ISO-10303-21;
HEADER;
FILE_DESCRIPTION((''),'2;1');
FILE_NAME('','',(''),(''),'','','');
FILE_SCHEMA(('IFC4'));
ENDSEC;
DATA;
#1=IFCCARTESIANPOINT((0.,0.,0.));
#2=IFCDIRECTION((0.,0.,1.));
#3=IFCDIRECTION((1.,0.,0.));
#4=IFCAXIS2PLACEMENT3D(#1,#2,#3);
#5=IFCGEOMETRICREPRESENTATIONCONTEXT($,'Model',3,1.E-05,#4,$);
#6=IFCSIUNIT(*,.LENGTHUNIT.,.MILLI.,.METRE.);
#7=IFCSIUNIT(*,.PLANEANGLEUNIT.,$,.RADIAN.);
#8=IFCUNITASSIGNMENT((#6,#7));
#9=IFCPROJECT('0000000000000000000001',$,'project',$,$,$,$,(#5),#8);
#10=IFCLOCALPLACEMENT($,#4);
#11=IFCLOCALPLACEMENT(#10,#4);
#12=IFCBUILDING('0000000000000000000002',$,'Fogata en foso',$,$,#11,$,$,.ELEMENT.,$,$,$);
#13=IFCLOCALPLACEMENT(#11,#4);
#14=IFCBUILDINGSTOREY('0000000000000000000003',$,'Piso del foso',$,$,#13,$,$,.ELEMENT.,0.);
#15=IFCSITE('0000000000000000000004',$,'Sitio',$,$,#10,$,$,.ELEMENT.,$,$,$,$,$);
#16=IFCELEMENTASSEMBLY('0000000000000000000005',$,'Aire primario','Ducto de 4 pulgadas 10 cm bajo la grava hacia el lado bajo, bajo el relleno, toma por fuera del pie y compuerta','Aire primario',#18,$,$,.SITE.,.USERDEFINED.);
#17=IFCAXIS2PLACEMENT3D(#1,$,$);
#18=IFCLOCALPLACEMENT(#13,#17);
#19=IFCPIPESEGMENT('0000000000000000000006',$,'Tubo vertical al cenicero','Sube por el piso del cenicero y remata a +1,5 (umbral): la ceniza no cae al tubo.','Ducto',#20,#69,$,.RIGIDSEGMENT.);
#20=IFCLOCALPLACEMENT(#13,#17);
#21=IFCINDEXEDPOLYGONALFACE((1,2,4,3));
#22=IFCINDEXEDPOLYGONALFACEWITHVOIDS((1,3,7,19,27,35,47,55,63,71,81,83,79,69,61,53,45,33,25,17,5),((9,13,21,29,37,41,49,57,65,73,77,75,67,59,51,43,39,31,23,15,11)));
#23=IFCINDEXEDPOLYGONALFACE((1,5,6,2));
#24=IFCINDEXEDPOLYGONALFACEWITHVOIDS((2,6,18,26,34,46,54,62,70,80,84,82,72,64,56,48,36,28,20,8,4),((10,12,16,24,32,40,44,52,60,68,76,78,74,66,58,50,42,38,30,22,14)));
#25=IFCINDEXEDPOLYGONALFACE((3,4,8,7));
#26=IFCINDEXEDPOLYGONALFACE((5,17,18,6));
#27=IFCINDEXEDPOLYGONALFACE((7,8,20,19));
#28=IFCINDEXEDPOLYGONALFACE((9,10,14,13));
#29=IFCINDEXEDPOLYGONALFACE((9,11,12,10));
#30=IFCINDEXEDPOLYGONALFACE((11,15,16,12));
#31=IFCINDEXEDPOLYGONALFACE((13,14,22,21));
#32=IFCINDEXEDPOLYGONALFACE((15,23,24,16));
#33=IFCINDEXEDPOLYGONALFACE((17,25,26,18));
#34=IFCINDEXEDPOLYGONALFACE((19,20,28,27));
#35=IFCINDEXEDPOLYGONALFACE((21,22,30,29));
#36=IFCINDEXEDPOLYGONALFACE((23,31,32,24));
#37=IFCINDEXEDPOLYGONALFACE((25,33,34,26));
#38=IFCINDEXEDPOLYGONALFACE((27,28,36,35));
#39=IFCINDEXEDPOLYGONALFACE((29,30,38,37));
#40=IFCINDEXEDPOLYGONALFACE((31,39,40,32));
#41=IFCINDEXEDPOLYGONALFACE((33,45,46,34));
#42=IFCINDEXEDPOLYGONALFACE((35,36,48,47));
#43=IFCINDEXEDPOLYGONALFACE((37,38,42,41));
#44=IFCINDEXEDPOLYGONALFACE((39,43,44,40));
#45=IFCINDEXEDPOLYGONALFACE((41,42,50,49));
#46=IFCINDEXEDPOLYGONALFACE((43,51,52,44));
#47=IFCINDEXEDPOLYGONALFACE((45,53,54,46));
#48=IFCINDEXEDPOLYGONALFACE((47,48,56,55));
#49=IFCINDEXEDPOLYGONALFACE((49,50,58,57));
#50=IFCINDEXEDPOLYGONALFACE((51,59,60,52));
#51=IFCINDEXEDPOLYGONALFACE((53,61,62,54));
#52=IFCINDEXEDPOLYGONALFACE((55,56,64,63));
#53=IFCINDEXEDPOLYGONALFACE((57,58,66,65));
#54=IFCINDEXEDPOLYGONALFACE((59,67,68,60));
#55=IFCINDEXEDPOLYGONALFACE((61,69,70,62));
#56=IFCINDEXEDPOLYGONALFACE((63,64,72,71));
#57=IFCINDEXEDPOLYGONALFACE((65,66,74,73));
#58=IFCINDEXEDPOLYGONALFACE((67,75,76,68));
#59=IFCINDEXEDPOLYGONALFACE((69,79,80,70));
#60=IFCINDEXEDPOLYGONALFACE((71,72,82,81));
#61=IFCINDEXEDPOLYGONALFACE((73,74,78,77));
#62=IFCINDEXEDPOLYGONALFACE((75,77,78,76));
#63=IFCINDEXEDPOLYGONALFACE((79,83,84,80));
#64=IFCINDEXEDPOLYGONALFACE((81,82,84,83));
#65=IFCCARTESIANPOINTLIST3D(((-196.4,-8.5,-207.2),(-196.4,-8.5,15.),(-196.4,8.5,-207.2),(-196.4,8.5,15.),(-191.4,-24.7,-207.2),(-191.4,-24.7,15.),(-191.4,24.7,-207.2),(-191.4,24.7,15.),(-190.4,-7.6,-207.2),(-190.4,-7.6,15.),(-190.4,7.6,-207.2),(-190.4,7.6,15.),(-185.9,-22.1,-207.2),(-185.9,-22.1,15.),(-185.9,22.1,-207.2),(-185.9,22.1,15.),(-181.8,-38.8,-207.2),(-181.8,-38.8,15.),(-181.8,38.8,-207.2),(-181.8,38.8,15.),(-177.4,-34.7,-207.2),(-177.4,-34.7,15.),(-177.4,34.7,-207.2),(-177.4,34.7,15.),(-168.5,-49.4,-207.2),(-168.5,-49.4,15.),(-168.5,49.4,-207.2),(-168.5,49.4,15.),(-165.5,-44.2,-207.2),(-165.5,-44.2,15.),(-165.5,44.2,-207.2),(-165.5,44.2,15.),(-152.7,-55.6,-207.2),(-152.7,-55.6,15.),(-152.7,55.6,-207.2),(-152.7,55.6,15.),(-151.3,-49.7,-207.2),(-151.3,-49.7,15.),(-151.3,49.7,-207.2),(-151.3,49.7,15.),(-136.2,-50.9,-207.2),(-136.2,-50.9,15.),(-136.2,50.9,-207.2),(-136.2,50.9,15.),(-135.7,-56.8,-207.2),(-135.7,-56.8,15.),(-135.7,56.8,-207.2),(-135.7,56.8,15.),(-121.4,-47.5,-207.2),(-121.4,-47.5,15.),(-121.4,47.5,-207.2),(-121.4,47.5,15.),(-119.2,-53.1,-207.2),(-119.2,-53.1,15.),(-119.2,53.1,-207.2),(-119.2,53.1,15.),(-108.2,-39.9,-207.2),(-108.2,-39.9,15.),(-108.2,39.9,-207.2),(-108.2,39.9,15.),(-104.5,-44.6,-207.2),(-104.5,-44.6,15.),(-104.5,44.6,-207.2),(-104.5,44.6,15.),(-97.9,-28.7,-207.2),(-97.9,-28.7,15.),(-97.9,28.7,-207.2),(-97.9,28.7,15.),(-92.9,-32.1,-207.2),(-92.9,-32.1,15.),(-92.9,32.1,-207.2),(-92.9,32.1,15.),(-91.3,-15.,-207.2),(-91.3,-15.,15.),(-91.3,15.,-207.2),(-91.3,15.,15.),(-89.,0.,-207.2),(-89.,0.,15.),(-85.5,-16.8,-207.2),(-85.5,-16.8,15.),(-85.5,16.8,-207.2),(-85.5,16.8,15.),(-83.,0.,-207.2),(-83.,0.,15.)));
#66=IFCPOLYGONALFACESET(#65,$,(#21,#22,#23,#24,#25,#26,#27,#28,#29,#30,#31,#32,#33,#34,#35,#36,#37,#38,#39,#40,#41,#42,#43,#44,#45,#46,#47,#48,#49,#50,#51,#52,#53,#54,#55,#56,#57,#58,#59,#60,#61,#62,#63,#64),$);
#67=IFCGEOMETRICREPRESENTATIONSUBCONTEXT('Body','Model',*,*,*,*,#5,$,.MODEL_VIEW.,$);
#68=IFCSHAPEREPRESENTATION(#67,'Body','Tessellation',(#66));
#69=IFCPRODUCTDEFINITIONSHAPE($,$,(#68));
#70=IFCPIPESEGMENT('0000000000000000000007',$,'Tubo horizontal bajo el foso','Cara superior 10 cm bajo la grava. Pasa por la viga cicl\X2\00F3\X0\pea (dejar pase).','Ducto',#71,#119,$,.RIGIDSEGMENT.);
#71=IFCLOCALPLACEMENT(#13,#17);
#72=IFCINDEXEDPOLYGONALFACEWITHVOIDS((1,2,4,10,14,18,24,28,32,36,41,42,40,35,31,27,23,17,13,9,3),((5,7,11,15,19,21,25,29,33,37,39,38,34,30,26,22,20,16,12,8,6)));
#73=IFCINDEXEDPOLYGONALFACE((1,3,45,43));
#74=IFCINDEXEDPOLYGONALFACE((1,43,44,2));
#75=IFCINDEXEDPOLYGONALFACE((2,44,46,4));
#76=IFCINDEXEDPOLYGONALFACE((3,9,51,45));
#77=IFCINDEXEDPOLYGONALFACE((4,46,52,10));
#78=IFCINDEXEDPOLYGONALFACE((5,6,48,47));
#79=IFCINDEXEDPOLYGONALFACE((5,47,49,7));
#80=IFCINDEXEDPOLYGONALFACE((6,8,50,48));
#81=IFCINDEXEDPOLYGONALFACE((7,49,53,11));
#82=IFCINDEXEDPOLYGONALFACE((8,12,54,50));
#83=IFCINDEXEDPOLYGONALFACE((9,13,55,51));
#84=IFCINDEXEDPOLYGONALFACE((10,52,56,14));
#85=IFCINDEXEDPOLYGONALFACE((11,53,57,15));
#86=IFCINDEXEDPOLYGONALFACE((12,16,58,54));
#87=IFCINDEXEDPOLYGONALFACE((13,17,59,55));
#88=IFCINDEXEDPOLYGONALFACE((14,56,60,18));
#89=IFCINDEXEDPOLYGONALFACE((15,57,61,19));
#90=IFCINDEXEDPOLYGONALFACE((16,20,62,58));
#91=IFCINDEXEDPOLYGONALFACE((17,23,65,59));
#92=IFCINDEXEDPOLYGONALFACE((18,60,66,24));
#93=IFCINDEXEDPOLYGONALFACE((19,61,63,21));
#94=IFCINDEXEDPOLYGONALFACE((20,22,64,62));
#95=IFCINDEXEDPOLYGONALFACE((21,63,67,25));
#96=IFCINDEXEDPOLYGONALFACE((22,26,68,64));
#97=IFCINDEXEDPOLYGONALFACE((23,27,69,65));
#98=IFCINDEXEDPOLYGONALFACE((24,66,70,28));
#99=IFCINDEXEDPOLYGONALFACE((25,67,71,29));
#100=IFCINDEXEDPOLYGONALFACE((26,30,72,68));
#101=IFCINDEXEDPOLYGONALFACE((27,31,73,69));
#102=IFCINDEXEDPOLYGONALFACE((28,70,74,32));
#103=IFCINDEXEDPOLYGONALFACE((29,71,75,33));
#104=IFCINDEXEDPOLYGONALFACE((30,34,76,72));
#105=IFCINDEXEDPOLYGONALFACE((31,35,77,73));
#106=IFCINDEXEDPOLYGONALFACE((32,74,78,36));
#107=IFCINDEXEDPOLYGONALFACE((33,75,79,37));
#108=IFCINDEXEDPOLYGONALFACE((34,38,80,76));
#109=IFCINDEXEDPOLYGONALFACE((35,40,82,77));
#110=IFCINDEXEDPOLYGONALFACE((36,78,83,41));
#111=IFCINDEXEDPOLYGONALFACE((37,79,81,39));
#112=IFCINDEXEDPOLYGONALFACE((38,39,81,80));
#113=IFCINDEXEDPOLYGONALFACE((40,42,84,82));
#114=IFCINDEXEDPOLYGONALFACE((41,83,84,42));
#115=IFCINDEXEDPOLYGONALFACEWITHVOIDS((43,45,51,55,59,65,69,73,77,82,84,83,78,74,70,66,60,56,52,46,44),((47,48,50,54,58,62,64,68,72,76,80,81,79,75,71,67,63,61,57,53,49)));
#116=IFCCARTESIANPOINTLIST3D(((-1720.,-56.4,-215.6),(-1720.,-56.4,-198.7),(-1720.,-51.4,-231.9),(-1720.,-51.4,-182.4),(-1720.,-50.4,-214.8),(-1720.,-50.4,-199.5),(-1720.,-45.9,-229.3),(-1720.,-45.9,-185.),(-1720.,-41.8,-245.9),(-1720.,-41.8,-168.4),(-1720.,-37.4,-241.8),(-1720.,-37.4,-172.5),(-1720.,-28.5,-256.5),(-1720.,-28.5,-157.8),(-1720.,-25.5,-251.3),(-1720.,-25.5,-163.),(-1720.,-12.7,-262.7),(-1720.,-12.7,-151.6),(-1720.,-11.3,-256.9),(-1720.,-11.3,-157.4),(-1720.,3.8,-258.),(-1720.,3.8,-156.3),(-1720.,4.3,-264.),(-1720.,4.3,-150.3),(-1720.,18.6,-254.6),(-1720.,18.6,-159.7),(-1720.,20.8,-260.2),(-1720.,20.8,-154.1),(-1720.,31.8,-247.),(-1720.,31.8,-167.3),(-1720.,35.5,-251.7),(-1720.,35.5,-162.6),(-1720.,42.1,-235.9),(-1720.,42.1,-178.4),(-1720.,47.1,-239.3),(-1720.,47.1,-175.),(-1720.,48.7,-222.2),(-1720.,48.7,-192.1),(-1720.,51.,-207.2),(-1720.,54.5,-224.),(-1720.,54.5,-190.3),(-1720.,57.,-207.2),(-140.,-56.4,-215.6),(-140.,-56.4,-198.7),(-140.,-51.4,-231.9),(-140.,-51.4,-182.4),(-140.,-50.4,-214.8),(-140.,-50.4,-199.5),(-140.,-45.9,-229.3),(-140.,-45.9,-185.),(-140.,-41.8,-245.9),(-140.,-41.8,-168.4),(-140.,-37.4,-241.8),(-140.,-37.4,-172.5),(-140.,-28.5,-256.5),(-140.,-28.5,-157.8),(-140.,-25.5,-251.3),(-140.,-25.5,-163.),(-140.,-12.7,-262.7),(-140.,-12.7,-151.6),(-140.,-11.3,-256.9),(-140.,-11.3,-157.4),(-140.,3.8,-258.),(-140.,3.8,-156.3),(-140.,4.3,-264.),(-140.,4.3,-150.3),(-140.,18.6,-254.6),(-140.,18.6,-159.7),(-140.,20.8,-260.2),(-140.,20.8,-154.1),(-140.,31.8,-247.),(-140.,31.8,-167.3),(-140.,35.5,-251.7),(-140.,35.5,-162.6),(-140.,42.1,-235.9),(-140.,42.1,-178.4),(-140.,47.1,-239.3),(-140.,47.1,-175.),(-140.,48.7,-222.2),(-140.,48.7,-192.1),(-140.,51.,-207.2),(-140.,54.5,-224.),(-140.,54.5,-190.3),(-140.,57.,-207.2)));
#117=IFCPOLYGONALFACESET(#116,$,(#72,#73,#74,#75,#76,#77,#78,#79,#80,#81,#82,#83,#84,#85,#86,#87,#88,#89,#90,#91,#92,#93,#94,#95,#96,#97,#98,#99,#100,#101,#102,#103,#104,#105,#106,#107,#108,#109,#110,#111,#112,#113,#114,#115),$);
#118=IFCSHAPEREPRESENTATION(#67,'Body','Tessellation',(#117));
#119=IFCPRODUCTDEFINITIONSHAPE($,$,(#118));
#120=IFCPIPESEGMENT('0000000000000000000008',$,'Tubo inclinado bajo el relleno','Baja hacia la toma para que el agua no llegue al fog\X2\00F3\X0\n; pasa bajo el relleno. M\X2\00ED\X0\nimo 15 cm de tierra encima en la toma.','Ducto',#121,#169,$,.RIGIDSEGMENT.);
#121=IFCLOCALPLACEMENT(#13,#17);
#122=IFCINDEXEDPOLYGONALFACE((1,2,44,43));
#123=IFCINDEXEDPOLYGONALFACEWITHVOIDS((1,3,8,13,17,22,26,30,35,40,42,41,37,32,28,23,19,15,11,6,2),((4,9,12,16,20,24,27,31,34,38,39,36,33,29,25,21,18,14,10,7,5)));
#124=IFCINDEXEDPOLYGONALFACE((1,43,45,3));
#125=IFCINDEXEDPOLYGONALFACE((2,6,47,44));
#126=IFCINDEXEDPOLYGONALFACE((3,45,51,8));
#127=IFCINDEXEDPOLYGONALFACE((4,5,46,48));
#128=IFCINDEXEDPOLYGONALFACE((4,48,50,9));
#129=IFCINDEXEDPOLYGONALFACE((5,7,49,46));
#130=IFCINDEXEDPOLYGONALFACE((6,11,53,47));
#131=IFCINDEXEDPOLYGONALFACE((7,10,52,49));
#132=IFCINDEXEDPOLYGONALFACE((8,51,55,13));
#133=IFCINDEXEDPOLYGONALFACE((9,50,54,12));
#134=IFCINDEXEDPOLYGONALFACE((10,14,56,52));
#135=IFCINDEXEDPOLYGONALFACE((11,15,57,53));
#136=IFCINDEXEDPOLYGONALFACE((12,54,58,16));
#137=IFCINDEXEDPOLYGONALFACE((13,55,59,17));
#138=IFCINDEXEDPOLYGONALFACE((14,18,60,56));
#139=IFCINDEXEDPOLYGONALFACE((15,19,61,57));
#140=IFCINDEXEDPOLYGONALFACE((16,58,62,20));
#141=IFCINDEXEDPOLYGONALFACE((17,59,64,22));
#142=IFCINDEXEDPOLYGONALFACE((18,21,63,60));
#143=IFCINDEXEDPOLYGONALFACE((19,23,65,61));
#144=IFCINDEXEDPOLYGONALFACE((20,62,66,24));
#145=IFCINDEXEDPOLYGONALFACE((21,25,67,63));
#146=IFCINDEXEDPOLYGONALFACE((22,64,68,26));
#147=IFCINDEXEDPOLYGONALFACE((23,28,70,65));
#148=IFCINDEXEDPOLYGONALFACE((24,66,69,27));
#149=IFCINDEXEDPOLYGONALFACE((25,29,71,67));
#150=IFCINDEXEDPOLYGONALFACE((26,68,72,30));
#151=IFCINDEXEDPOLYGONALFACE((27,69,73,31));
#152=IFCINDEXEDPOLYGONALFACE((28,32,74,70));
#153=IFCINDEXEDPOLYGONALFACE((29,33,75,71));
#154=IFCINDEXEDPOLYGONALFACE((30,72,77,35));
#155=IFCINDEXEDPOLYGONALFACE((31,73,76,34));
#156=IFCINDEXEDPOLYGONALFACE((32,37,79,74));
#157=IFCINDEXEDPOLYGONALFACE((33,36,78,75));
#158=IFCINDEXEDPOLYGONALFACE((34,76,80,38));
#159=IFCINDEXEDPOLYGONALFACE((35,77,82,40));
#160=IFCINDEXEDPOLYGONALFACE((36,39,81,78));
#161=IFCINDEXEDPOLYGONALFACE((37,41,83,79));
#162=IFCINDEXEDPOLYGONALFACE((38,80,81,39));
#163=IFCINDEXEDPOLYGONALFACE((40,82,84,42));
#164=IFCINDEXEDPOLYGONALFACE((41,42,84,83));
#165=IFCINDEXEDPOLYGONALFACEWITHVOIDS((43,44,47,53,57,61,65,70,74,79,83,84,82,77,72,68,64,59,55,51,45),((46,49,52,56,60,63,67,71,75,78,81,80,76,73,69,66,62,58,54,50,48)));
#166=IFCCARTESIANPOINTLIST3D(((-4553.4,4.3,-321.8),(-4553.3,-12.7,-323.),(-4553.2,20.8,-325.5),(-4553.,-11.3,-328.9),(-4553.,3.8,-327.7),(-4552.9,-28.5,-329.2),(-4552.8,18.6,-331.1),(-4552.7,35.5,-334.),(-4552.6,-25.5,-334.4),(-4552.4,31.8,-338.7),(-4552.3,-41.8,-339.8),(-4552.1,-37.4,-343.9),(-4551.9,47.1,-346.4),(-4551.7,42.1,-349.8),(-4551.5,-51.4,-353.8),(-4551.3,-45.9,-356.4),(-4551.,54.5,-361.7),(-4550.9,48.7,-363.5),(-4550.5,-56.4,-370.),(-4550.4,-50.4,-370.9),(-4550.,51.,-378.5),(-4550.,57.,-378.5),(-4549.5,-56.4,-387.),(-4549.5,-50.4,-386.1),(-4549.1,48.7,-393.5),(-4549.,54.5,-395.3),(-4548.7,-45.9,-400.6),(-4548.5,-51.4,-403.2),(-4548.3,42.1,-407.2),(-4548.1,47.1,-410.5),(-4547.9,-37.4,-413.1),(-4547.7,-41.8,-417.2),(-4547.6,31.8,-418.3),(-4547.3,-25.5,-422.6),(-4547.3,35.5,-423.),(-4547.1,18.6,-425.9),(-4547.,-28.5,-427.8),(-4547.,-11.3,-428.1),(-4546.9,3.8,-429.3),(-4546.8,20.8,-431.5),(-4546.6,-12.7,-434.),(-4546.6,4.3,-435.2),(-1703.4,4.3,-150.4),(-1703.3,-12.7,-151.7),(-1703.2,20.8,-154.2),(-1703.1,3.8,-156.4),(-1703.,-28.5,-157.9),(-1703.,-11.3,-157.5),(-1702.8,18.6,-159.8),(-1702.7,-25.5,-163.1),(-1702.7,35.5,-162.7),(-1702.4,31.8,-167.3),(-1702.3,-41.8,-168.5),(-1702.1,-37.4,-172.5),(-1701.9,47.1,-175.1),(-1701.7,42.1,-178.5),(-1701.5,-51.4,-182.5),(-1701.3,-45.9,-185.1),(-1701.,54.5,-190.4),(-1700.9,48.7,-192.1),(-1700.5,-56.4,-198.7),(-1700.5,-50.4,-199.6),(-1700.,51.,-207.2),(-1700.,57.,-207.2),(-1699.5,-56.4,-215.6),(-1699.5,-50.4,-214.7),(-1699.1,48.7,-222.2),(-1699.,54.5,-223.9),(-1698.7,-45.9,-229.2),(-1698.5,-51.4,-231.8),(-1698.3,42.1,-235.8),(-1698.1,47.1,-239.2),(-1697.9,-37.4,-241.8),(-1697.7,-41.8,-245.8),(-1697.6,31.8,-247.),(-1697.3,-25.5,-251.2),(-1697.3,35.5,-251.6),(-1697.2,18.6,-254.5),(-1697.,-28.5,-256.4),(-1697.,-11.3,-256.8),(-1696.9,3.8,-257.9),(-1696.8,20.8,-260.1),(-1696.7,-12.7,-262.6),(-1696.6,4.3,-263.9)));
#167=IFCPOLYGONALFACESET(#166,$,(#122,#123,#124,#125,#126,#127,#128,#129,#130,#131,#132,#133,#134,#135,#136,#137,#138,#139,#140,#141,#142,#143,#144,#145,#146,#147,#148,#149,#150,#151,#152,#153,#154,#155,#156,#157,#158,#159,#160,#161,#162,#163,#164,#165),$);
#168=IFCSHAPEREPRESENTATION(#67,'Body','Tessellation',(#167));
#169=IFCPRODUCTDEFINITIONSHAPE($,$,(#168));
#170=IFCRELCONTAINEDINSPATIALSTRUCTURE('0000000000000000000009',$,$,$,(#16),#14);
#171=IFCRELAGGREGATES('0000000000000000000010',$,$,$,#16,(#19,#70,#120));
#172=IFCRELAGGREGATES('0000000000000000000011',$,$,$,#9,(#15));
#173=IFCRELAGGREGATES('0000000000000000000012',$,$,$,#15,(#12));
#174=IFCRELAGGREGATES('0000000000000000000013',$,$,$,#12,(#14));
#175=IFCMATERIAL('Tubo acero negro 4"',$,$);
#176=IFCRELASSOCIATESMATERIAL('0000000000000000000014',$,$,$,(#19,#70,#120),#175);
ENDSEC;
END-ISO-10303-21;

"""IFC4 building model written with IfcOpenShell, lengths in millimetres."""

from ifc_helpers import new_model, si_unit, frame, origin_with_axes, origin_2d, place, context, subcontext, project, spatial, hollow_circle, extrude, material, element, aggregate, save


model = new_model("IFC4")

# Units and contexts
model_context = context("Model", 3, precision=1e-05, world=origin_with_axes())
body_context = subcontext(model_context, "Body", "Model", "MODEL_VIEW")
ifc_project = project(units=[si_unit("LENGTHUNIT", "METRE", prefix="MILLI"), si_unit("PLANEANGLEUNIT", "RADIAN")], contexts=[model_context])

# Site, building, storey
site_placement = place(None, origin_with_axes())
site = spatial("IfcSite", under=ifc_project, at=site_placement, Name="Sitio", CompositionType="ELEMENT")
building_placement = place(site_placement, origin_with_axes())
building = spatial("IfcBuilding", under=site, at=building_placement, Name="Fogata en foso", CompositionType="ELEMENT")
storey_placement = place(building_placement, origin_with_axes())
storey = spatial("IfcBuildingStorey", under=building, at=storey_placement, Name="Piso del foso", CompositionType="ELEMENT", Elevation=0.0)

# Element assembly, pipe segments
assembly_1_placement = place(storey_placement, origin_with_axes())
assembly_1 = element("IfcElementAssembly", 1, at=assembly_1_placement, inside=storey, Name="Aire primario", Description="Ducto de 4 pulgadas 10 cm bajo la grava hacia el lado bajo, bajo el relleno, toma por fuera del pie y compuerta", ObjectType="Aire primario", AssemblyPlace="SITE", PredefinedType="USERDEFINED")
ifc_material_1 = material(Name="Tubo acero negro 4\"")
pipe_segment_1_placement = place(storey_placement, frame((-140.0, 0.0, -207.2), z_axis=(0.0, 0.0, 1.0), x_axis=(1.0, 0.0, 0.0)))
pipe_segment_1 = element("IfcPipeSegment", 2, at=pipe_segment_1_placement, material=ifc_material_1, Name="Tubo vertical al cenicero", Description="Sube por el piso del cenicero y remata a +1,5 (umbral): la ceniza no cae al tubo.", ObjectType="Ducto", PredefinedType="RIGIDSEGMENT", context=body_context, shape_type="SweptSolid", body=[
    extrude(hollow_circle(Radius=57.0, WallThickness=6.0, at=origin_2d()), origin_with_axes(), (0.0, 0.0, 1.0), 222.2),
])
pipe_segment_2_placement = place(storey_placement, frame((-140.0, 0.0, -207.2), z_axis=(-1.0, 0.0, 0.0), x_axis=(0.0, 1.0, 0.0)))
pipe_segment_2 = element("IfcPipeSegment", 3, at=pipe_segment_2_placement, material=ifc_material_1, Name="Tubo horizontal bajo el foso", Description="Cara superior 10 cm bajo la grava. Pasa por la viga ciclópea (dejar pase).", ObjectType="Ducto", PredefinedType="RIGIDSEGMENT", context=body_context, shape_type="SweptSolid", body=[
    extrude(hollow_circle(Radius=57.0, WallThickness=6.0, at=origin_2d()), origin_with_axes(), (0.0, 0.0, 1.0), 1580.0),
])
pipe_segment_3_placement = place(storey_placement, frame((-1700.0, 0.0, -207.2), z_axis=(-0.998, 0.0, -0.06), x_axis=(0.0, 1.0, 0.0)))
pipe_segment_3 = element("IfcPipeSegment", 4, at=pipe_segment_3_placement, material=ifc_material_1, Name="Tubo inclinado bajo el relleno", Description="Baja hacia la toma para que el agua no llegue al fogón; pasa bajo el relleno. Mínimo 15 cm de tierra encima en la toma.", ObjectType="Ducto", PredefinedType="RIGIDSEGMENT", context=body_context, shape_type="SweptSolid", body=[
    extrude(hollow_circle(Radius=57.0, WallThickness=6.0, at=origin_2d()), origin_with_axes(), (0.0, 0.0, 1.0), 2855.1),
])
aggregate(assembly_1, [pipe_segment_1, pipe_segment_2, pipe_segment_3])

save(model, "model.ifc")
